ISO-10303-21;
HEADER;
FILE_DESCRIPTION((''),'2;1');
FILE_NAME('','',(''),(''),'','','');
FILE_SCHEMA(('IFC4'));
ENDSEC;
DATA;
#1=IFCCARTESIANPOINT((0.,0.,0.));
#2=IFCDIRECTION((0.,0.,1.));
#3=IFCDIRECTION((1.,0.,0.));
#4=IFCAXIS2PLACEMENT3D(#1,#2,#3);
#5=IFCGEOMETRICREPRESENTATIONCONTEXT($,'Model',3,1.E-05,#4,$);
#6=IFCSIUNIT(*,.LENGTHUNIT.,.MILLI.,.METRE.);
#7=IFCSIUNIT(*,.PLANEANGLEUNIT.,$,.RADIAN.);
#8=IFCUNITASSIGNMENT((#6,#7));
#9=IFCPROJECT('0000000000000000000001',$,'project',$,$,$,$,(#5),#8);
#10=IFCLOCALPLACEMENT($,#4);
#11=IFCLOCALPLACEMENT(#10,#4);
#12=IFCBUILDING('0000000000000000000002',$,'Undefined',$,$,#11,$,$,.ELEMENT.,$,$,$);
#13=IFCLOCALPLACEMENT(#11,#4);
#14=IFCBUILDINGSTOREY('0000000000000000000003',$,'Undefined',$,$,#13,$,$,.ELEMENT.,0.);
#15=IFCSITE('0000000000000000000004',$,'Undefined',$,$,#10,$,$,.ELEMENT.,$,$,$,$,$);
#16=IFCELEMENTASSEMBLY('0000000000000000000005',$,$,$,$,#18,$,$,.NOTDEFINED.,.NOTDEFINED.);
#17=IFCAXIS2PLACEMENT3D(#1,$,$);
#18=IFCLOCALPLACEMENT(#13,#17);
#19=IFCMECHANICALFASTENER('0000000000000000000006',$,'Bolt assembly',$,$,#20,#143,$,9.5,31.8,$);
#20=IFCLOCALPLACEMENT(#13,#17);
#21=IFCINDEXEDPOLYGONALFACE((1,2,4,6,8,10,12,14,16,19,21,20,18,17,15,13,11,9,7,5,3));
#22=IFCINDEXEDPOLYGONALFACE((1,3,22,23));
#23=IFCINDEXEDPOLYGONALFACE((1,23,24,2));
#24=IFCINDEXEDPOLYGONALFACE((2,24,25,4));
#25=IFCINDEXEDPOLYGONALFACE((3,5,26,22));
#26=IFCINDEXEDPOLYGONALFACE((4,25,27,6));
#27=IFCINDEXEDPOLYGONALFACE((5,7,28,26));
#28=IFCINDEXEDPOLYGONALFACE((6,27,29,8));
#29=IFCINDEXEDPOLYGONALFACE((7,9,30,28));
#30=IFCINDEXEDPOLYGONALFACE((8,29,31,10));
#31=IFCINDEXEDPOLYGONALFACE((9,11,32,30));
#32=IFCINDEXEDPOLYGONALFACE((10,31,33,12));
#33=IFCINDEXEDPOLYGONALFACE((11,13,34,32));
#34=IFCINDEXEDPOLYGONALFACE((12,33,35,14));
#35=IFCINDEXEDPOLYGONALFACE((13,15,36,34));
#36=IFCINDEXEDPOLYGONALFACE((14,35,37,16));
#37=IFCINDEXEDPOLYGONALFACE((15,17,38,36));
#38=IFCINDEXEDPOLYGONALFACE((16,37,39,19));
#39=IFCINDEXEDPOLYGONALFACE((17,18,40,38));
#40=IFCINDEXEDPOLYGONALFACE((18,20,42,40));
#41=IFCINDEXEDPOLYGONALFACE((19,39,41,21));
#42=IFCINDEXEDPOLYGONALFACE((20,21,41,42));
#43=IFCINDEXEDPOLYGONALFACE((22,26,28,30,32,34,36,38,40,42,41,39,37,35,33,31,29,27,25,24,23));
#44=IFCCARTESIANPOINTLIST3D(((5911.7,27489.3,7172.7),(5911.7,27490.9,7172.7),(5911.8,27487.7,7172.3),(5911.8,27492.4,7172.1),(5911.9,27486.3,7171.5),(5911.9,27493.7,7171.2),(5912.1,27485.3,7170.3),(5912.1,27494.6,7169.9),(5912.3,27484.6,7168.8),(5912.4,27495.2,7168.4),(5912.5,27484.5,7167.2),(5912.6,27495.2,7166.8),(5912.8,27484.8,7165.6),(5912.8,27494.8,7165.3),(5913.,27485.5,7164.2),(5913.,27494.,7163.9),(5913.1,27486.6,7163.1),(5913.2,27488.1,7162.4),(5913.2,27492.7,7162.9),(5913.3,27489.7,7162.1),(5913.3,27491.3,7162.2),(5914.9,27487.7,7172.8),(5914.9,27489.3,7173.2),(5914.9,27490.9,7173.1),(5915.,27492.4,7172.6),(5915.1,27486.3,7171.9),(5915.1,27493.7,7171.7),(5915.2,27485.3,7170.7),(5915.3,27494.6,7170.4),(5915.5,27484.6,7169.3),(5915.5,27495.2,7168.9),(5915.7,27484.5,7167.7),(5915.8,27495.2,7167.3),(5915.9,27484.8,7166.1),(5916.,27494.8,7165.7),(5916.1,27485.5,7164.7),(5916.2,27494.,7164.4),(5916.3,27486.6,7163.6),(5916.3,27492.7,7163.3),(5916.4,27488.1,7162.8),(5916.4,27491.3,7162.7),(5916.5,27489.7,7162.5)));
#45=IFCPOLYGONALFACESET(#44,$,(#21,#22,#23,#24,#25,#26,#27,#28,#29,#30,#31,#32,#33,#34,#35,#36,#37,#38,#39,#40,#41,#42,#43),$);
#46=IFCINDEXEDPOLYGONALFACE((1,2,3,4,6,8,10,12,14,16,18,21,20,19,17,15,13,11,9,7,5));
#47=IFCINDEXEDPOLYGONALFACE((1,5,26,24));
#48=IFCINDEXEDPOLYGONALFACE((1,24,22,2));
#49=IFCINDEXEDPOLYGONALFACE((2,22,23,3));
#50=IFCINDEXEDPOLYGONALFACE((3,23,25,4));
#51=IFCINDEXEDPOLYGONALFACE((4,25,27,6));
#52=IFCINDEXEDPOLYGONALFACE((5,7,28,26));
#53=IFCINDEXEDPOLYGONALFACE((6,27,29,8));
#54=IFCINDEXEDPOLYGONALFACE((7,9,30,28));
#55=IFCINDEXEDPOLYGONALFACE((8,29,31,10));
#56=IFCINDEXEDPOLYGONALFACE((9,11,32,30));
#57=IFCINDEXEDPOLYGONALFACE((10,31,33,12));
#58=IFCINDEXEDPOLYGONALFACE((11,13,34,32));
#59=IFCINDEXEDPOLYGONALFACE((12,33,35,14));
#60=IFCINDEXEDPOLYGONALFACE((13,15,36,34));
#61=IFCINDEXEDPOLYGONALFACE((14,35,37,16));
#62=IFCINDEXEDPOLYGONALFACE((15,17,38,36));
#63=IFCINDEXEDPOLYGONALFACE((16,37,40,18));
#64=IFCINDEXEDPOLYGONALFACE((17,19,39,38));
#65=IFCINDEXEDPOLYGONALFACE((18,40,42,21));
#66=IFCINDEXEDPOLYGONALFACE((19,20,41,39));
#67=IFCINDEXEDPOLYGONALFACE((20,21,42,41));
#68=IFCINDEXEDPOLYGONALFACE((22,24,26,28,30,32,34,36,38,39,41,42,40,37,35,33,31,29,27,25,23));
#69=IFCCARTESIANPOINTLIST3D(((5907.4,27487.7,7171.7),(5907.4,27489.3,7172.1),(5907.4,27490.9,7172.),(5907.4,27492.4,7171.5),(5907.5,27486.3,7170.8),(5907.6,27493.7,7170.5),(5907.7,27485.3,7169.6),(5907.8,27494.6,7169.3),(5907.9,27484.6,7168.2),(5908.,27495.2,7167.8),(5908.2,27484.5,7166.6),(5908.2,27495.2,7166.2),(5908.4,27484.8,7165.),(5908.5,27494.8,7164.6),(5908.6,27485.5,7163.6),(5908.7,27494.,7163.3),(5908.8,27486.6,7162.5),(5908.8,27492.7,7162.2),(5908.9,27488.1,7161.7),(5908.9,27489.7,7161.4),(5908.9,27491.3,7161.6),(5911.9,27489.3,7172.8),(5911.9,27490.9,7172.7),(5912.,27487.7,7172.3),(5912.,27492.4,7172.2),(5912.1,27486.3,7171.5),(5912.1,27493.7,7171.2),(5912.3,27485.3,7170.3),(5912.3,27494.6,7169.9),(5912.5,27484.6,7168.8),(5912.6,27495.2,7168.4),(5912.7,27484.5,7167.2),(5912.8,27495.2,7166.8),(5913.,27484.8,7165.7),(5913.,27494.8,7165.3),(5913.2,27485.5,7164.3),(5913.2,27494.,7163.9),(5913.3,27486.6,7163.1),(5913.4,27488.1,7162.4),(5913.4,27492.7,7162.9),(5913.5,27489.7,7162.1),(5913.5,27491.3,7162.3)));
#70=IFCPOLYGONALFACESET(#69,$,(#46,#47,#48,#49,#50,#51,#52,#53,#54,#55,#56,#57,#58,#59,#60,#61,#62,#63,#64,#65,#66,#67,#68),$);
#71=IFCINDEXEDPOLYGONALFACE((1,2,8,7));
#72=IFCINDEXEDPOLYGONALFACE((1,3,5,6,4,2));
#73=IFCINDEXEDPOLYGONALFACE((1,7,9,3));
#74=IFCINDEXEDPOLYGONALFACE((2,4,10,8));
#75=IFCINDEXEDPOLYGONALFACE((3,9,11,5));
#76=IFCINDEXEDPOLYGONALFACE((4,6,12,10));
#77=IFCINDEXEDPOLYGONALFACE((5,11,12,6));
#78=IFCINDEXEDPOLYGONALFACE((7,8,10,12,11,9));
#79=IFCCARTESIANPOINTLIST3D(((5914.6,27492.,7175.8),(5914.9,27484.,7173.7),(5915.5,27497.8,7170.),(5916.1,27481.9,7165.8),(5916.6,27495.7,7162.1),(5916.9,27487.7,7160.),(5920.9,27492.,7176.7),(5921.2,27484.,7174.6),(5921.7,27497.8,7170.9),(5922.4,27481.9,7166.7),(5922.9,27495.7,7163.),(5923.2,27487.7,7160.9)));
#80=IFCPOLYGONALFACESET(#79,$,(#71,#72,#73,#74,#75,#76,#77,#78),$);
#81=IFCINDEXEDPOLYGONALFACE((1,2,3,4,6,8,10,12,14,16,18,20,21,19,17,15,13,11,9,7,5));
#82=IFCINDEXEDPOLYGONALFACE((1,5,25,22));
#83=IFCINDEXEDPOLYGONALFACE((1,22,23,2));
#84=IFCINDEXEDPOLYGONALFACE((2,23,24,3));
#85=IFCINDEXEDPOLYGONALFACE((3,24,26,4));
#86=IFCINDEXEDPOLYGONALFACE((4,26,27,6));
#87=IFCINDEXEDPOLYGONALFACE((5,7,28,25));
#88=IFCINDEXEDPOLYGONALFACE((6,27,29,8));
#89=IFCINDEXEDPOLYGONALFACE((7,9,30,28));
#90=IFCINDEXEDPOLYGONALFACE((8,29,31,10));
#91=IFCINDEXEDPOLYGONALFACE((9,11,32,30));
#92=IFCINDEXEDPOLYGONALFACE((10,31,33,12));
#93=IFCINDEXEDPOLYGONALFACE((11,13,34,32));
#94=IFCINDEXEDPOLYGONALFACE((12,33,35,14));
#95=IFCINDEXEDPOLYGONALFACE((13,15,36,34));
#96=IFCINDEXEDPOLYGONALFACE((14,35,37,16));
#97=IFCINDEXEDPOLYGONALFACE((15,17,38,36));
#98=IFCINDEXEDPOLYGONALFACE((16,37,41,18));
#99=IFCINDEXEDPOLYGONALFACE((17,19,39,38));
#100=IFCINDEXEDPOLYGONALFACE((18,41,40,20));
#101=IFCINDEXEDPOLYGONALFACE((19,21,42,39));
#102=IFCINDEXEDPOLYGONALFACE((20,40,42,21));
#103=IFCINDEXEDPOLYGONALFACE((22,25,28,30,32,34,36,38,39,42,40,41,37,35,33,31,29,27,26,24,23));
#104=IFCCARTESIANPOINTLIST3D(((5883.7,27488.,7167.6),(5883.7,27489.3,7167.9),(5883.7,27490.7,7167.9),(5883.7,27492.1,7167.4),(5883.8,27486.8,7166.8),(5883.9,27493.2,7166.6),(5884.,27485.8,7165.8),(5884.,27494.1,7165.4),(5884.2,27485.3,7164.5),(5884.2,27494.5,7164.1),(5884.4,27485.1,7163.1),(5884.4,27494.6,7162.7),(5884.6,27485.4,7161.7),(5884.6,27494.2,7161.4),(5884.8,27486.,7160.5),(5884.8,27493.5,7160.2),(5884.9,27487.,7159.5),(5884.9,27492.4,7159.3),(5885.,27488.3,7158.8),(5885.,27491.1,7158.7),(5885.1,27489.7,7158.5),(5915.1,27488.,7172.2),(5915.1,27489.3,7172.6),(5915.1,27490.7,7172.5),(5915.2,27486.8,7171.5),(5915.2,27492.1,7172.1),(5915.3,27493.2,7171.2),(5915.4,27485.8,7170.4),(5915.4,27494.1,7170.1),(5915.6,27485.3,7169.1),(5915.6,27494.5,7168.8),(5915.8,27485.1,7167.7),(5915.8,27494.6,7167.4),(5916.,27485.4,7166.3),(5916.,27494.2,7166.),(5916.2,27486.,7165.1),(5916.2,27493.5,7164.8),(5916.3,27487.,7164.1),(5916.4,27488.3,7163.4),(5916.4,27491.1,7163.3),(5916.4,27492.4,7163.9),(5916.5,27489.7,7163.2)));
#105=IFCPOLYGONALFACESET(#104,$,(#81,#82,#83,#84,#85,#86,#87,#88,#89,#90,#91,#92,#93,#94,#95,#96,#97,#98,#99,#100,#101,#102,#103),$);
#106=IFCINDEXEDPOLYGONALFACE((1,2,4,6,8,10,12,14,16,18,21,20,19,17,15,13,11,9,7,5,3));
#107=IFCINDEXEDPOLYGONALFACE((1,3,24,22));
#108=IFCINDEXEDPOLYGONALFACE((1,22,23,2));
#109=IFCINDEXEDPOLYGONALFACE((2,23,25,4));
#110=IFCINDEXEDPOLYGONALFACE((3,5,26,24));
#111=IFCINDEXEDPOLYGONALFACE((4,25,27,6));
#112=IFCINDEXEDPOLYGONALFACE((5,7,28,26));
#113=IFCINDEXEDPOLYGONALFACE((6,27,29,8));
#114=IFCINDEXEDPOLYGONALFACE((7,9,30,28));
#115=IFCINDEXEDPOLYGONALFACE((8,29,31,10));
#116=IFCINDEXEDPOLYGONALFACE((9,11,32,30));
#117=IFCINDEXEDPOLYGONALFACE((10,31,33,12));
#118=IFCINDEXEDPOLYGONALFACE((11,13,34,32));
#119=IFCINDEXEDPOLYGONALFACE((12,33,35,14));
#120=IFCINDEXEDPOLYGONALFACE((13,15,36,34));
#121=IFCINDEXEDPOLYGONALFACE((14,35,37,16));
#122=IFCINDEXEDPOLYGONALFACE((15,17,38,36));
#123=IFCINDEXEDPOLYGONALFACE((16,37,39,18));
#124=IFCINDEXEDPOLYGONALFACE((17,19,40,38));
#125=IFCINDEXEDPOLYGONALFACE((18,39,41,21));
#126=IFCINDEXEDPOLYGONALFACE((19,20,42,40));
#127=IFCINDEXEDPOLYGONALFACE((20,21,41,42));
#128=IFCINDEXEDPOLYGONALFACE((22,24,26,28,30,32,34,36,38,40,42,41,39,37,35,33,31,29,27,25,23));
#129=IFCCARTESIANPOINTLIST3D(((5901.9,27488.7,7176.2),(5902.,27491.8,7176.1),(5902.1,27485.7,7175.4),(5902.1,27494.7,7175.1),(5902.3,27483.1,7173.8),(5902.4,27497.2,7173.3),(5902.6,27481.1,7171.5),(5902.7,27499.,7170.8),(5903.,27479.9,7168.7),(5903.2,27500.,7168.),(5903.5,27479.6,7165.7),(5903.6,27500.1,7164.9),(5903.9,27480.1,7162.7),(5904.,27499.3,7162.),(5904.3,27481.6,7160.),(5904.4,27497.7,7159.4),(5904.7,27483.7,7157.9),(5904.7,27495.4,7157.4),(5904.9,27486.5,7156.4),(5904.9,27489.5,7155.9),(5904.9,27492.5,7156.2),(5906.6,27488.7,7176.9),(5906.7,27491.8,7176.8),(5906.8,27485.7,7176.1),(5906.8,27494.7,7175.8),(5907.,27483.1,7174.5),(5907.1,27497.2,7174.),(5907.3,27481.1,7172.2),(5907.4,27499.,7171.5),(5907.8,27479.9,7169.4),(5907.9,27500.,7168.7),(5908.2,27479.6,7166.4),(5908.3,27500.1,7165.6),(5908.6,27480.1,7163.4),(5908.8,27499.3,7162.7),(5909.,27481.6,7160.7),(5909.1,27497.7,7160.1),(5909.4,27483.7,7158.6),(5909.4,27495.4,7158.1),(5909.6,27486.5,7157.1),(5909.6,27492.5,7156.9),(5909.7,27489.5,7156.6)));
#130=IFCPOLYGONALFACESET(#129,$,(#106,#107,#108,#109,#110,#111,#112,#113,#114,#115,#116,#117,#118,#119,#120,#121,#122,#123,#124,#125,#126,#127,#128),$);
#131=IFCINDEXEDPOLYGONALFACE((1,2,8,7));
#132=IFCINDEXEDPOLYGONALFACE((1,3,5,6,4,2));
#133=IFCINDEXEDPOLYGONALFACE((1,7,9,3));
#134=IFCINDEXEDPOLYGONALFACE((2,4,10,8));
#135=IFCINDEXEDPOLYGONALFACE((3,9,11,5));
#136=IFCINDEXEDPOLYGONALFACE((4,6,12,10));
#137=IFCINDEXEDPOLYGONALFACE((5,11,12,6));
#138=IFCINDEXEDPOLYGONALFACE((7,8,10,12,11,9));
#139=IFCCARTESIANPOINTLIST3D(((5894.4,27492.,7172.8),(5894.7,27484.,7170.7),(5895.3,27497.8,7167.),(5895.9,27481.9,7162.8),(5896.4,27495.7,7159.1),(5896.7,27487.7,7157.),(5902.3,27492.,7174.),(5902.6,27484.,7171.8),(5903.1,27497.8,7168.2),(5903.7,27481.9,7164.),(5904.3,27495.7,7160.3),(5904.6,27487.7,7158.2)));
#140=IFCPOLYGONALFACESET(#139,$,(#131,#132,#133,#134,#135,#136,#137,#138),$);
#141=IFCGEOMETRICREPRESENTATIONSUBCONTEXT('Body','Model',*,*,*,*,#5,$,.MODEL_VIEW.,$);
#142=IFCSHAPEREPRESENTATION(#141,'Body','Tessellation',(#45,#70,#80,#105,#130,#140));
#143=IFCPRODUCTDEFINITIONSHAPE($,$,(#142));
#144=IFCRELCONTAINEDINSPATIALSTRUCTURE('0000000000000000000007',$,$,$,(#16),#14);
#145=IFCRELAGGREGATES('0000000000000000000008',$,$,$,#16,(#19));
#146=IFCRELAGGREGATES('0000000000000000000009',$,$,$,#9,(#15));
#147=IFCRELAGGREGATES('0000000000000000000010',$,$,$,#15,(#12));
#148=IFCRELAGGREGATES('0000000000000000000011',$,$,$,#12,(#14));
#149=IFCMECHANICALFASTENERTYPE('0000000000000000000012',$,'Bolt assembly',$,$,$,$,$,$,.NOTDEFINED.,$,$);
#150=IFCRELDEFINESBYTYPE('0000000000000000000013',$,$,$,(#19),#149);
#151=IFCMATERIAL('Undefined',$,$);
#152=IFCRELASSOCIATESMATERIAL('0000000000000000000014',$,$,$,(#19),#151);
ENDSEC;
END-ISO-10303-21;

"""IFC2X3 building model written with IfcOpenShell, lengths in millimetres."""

from ifc_helpers import new_model, si_unit, frame, origin_with_axes, origin_2d_with_axis, place, context, subcontext, project, spatial, polyline, circle, outline, extrude, source, transform, mapped, material, type_object, element, aggregate, save


model = new_model("IFC2X3")

# Units and contexts
model_context = context("Model", 3, precision=1e-05, world=origin_with_axes())
body_context = subcontext(model_context, "Body", "Model", "MODEL_VIEW")
ifc_project = project(units=[si_unit("LENGTHUNIT", "METRE", prefix="MILLI"), si_unit("PLANEANGLEUNIT", "RADIAN")], contexts=[model_context])

# Site, building, storey
site_placement = place(None, origin_with_axes())
site = spatial("IfcSite", under=ifc_project, at=site_placement, Name="Undefined", CompositionType="ELEMENT")
building_placement = place(site_placement, origin_with_axes())
building = spatial("IfcBuilding", under=site, at=building_placement, Name="Undefined", CompositionType="ELEMENT")
storey_placement = place(building_placement, origin_with_axes())
storey = spatial("IfcBuildingStorey", under=building, at=storey_placement, Name="Undefined", CompositionType="ELEMENT", Elevation=0.0)

# Element assembly
assembly_1_placement = place(storey_placement, origin_with_axes())
assembly_1 = element("IfcElementAssembly", 1, at=assembly_1_placement, inside=storey, AssemblyPlace="NOTDEFINED", PredefinedType="NOTDEFINED")

# Shared definitions
ifc_material_1 = material(Name="Undefined")
mechanical_fastener_type = type_object("IfcMechanicalFastenerType", Name="Bolt assembly")

# Mechanical fastener
shared_shape_1 = source(origin_with_axes(), body_context, "Body", "SweptSolid", [
    extrude(circle(Radius=5.4, at=origin_2d_with_axis()), frame((0.0, -3.1, 0.0), z_axis=(0.0, 1.0, 0.0), x_axis=(1.0, 0.0, 0.0)), (0.0, 0.0, 1.0), 3.2),
    extrude(circle(Radius=5.4, at=origin_2d_with_axis()), frame((0.0, -0.1, 0.0), z_axis=(0.0, 1.0, 0.0), x_axis=(1.0, 0.0, 0.0)), (0.0, 0.0, 1.0), 4.6),
    extrude(outline(polyline([(7.1, -4.1), (7.1, 4.1), (0.0, 8.2), (-7.1, 4.1), (-7.1, -4.1), (0.0, -8.2), (7.1, -4.1)])), frame((0.0, -9.6, 0.0), z_axis=(0.0, 1.0, 0.0), x_axis=(1.0, 0.0, 0.0)), (0.0, 0.0, 1.0), 6.3),
    extrude(circle(Radius=4.8, at=origin_2d_with_axis()), frame((0.0, -3.2, 0.0), z_axis=(0.0, 1.0, 0.0), x_axis=(1.0, 0.0, 0.0)), (0.0, 0.0, 1.0), 31.8),
    extrude(circle(Radius=10.3, at=origin_2d_with_axis()), frame((0.0, 4.5, 0.0), z_axis=(0.0, 1.0, 0.0), x_axis=(1.0, 0.0, 0.0)), (0.0, 0.0, 1.0), 4.8),
    extrude(outline(polyline([(7.1, -4.1), (7.1, 4.1), (0.0, 8.2), (-7.1, 4.1), (-7.1, -4.1), (0.0, -8.2), (7.1, -4.1)])), frame((0.0, 9.3, 0.0), z_axis=(0.0, 1.0, 0.0), x_axis=(1.0, 0.0, 0.0)), (0.0, 0.0, 1.0), 7.9),
])
mechanical_fastener_1_placement = place(assembly_1_placement, frame((5912.6, 27489.9, 7167.4), z_axis=(-0.103381, -0.707107, 0.699509), x_axis=(-0.103381, 0.707107, 0.699509)))
mechanical_fastener_1 = element("IfcMechanicalFastener", 2, at=mechanical_fastener_1_placement, type_object=mechanical_fastener_type, material=ifc_material_1, Name="Bolt assembly", NominalDiameter=9.5, NominalLength=31.8, context=body_context, shape_type="MappedRepresentation", body=[
    mapped(shared_shape_1, transform((0.0, 0.0, 0.0))),
])
aggregate(assembly_1, [mechanical_fastener_1])

save(model, "model.ifc")
